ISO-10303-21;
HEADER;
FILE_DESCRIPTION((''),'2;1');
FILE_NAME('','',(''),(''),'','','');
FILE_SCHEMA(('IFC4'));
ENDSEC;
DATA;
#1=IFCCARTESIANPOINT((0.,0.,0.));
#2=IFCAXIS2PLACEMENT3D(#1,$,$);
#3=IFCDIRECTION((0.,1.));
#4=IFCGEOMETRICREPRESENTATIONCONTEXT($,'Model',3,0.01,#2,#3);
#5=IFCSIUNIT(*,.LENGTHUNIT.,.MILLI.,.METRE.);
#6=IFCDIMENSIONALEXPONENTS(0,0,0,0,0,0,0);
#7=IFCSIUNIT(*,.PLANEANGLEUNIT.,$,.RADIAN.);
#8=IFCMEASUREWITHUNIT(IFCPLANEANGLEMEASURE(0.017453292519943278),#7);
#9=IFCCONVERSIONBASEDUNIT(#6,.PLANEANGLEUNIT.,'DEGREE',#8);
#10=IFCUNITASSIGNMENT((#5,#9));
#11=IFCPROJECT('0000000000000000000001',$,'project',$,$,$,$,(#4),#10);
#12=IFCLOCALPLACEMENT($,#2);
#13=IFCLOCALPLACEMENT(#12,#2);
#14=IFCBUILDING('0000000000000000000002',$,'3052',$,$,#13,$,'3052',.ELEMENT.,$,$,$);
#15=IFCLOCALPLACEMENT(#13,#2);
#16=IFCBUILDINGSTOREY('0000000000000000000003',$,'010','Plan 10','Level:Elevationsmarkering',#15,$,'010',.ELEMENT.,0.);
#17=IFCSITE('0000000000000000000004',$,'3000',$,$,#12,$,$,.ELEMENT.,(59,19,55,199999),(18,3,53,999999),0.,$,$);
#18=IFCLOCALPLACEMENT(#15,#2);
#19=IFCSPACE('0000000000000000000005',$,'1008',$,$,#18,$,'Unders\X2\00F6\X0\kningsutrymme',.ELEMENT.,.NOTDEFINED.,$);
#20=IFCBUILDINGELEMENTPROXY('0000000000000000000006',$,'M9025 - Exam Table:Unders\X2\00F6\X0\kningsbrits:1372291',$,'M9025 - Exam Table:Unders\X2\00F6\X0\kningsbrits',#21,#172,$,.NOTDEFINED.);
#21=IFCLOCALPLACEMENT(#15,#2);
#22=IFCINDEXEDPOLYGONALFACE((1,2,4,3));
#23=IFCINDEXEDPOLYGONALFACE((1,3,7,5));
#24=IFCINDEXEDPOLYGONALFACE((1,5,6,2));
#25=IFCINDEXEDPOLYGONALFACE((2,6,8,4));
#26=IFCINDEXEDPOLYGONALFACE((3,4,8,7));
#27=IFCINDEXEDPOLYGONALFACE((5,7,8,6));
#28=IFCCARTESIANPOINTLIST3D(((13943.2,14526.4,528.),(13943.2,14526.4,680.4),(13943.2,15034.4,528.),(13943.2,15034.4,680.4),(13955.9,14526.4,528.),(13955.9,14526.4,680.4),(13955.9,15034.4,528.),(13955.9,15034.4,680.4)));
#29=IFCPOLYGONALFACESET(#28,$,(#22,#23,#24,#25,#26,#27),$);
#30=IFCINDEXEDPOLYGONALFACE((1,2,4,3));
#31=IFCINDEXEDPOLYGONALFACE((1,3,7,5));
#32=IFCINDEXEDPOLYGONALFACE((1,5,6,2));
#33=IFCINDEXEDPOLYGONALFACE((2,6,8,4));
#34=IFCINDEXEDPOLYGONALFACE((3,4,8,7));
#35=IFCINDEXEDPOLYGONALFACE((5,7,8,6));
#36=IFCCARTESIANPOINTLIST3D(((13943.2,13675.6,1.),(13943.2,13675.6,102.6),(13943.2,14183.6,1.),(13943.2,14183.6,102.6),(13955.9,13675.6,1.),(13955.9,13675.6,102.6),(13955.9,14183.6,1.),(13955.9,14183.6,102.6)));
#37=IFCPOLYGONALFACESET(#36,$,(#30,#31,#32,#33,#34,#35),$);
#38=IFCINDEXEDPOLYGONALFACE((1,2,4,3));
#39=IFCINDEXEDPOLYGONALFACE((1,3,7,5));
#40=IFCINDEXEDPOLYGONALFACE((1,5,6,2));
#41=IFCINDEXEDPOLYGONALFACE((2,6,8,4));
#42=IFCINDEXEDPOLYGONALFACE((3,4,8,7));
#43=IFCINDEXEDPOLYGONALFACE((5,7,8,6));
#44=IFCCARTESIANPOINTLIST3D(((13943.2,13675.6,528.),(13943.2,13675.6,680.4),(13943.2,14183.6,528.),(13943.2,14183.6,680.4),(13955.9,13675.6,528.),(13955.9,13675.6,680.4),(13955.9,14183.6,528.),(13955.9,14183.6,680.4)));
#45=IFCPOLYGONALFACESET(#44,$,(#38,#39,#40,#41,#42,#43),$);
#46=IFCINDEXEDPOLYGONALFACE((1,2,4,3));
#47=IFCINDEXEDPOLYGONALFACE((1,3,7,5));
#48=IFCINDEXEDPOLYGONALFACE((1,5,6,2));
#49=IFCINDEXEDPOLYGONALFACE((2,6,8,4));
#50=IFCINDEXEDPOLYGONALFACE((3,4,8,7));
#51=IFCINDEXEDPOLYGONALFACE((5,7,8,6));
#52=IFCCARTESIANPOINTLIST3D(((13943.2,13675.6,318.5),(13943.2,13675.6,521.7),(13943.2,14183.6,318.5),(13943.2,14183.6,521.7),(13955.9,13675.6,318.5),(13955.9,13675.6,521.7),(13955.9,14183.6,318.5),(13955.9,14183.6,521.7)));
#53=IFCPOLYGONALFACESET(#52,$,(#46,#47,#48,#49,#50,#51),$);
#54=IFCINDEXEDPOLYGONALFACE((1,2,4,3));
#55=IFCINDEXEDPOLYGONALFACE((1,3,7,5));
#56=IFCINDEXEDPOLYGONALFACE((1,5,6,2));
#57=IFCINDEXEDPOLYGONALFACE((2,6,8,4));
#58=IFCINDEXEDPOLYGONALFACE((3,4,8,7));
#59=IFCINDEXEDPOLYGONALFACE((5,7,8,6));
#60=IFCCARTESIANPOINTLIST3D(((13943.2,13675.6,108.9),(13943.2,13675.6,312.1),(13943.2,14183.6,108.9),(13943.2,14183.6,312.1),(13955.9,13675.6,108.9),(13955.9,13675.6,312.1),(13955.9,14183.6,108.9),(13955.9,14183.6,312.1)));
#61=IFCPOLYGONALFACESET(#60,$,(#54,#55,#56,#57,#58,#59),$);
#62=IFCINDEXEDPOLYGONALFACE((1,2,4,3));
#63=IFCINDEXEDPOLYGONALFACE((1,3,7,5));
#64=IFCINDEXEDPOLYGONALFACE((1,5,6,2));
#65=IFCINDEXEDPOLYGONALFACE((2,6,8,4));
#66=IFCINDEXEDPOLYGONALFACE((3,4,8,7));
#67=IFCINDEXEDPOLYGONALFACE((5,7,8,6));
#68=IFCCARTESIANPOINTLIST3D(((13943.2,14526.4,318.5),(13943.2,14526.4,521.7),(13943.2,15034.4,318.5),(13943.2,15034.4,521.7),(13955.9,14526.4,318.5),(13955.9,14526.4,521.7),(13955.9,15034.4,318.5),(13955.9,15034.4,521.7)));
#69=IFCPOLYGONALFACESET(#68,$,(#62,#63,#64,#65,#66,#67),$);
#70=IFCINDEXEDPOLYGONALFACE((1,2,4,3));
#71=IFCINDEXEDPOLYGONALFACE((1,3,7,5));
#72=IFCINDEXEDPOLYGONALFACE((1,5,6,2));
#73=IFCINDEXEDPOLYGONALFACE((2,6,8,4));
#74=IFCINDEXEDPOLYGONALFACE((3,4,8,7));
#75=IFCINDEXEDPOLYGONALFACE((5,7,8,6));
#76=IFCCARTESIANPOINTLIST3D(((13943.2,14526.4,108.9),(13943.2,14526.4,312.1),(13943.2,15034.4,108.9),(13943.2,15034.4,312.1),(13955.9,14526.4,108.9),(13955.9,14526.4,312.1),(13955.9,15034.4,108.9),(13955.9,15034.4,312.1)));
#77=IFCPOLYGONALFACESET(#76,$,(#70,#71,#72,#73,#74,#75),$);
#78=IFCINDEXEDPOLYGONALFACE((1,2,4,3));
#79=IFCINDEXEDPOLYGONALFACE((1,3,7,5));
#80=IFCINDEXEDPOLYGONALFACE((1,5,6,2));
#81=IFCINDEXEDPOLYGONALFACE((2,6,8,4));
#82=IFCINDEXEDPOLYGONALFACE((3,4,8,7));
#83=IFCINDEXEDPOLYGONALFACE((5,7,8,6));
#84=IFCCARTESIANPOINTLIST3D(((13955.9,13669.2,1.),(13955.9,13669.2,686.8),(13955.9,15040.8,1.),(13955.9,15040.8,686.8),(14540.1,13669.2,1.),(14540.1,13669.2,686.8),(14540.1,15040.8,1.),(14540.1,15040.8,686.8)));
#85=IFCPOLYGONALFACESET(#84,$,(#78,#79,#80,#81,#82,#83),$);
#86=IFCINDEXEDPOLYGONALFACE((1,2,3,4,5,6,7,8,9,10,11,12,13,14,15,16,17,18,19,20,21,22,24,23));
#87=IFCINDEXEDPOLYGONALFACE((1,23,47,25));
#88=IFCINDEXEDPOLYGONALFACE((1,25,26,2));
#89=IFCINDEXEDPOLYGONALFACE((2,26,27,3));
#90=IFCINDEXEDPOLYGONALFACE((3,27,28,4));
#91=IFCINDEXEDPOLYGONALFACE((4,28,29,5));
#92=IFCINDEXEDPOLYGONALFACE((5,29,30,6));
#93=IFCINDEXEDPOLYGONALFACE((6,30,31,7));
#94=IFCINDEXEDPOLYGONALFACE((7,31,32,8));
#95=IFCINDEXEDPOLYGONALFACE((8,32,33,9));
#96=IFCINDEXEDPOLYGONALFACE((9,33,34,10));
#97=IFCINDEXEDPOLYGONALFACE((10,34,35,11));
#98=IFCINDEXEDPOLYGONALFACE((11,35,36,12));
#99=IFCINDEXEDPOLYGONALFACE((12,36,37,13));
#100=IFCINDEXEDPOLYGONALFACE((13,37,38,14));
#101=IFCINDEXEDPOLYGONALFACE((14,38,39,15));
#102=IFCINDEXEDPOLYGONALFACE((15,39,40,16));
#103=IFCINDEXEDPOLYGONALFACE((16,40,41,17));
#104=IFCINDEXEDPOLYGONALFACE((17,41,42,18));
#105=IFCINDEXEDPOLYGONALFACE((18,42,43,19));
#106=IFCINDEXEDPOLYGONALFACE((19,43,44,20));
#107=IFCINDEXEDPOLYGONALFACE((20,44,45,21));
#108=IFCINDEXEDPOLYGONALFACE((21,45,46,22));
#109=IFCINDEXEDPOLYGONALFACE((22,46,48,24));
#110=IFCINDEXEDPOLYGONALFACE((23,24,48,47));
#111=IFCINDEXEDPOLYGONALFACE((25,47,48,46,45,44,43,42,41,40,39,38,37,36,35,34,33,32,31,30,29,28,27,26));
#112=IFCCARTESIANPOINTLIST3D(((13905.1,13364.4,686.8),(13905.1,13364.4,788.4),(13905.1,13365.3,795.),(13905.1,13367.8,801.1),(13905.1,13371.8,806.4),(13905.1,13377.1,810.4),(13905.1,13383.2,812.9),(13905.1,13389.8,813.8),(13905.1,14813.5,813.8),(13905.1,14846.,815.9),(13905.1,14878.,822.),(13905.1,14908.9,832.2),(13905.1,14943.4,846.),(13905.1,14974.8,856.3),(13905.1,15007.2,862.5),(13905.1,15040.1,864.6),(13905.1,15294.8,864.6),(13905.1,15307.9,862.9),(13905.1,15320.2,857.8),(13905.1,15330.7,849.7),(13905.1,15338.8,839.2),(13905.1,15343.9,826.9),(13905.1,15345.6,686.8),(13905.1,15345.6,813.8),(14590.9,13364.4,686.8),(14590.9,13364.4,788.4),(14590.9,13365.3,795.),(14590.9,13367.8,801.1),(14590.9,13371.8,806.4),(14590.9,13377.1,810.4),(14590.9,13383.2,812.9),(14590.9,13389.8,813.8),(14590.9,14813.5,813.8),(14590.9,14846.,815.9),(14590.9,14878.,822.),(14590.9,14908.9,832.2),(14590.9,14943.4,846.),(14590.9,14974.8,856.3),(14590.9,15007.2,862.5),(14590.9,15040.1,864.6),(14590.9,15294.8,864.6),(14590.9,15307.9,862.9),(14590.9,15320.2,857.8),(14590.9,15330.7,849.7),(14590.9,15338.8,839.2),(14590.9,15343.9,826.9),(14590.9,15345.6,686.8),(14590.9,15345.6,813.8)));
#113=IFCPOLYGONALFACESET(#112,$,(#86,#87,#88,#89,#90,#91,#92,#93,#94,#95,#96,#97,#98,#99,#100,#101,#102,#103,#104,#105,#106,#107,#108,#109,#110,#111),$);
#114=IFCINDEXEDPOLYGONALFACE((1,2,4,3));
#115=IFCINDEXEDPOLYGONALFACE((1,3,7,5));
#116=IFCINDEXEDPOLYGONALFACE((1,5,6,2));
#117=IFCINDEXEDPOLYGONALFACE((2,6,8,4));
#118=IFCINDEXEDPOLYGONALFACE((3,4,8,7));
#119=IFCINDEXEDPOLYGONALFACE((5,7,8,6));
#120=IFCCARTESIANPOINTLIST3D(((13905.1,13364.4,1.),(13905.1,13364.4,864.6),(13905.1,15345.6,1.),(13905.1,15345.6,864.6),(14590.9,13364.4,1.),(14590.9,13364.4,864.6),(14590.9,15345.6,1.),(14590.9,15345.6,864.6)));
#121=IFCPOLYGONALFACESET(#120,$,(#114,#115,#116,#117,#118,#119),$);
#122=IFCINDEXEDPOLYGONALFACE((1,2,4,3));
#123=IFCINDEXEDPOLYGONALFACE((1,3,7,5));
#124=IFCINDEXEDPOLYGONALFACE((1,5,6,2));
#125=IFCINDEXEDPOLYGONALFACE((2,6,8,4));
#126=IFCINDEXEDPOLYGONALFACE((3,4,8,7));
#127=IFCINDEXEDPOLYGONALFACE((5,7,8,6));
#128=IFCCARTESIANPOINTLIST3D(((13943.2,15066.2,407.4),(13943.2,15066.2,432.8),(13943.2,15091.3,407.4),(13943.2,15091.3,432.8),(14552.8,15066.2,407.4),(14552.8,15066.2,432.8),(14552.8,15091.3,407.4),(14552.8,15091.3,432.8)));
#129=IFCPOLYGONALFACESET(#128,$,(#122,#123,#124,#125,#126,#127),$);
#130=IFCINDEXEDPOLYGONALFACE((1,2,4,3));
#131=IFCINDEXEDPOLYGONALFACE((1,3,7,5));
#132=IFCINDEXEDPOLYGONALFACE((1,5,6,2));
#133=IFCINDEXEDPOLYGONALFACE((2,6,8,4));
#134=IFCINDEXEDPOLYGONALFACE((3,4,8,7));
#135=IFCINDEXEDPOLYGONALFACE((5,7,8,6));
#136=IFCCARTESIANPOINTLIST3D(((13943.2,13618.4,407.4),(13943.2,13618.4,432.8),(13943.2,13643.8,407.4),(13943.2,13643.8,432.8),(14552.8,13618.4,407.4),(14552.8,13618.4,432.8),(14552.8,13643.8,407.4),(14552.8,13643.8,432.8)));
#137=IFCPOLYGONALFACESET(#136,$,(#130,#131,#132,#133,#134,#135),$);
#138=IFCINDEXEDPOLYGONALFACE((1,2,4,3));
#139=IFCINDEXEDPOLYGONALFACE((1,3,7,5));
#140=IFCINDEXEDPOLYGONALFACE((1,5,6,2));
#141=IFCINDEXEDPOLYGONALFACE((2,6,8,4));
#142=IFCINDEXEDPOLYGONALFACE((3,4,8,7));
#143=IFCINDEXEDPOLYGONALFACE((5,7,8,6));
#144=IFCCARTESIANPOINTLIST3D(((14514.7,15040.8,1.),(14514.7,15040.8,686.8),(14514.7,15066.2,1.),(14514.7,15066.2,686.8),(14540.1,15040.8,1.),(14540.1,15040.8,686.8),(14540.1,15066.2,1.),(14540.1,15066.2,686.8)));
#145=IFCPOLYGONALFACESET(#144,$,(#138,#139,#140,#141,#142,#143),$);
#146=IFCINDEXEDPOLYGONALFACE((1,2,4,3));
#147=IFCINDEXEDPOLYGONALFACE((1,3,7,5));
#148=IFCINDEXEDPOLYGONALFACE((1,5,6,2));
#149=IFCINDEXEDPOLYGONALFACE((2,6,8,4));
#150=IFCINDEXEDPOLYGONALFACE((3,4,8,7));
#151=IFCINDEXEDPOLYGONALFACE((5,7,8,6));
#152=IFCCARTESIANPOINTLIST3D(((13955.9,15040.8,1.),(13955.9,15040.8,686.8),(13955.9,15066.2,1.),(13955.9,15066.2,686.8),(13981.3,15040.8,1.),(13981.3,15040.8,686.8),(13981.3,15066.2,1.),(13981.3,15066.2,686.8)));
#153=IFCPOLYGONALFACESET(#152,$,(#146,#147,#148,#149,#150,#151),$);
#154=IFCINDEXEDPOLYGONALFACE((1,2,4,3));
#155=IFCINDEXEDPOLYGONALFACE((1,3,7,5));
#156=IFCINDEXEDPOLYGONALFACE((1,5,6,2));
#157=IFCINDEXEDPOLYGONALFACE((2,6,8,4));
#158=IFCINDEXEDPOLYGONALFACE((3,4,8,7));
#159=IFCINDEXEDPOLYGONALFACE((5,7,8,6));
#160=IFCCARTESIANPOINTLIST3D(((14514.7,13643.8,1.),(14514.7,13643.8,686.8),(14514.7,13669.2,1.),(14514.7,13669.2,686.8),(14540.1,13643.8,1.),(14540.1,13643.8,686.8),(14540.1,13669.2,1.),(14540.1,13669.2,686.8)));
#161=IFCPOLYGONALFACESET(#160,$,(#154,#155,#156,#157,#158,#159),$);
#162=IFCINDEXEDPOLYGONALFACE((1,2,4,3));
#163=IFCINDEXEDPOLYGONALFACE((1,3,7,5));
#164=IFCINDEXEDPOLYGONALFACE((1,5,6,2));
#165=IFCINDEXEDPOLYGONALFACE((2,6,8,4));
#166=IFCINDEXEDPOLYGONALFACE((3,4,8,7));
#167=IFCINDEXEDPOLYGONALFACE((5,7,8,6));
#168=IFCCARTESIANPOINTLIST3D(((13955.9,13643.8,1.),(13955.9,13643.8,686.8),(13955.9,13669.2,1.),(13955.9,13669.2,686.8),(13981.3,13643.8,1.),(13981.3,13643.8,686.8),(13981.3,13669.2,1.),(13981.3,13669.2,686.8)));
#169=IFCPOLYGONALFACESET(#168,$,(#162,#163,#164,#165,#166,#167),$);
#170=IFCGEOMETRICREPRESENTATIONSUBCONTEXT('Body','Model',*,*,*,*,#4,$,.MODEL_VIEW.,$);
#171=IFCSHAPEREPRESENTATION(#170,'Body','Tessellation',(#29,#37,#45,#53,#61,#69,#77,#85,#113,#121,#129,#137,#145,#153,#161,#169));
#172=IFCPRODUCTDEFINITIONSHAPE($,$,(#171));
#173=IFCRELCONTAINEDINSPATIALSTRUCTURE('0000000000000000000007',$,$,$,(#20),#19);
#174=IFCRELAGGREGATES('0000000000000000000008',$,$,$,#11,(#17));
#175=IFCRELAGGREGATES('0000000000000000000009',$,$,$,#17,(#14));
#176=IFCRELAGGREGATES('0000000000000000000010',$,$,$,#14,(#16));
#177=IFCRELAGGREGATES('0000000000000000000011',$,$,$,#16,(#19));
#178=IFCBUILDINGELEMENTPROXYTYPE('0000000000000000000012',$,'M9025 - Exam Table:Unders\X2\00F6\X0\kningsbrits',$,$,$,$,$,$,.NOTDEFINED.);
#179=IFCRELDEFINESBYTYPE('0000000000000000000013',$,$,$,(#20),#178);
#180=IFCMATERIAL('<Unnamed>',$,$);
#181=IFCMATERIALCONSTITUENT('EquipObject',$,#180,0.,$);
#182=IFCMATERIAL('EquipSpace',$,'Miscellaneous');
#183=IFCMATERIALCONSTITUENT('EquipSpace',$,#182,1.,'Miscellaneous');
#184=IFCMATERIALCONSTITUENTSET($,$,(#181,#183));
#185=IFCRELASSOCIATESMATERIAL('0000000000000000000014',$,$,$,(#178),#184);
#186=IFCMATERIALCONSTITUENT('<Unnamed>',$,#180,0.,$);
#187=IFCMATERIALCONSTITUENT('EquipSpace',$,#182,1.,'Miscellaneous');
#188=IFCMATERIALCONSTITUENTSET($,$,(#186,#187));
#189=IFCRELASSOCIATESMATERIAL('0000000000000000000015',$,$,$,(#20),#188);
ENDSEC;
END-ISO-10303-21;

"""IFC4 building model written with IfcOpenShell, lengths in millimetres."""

from ifc_helpers import new_model, entity, si_unit, converted_unit, direction, frame, origin, place, context, subcontext, project, spatial, line, arc, indexed_curve, outline, extrude, source, transform, mapped, material, constituent, constituent_set, type_object, type_shapes, element, save


model = new_model("IFC4")

# Units and contexts
model_context = context("Model", 3, precision=0.01, world=origin(), true_north=direction((0.0, 1.0)))
body_context = subcontext(model_context, "Body", "Model", "MODEL_VIEW")
ifc_project = project(units=[si_unit("LENGTHUNIT", "METRE", prefix="MILLI"), converted_unit("PLANEANGLEUNIT", "DEGREE", entity("IfcPlaneAngleMeasure", 0.017453292519943278), si_unit("PLANEANGLEUNIT", "RADIAN"), dimensions=[0, 0, 0, 0, 0, 0, 0])], contexts=[model_context])

# Site, building, storey
site_placement = place(None, origin())
site = spatial("IfcSite", under=ifc_project, at=site_placement, Name="3000", CompositionType="ELEMENT", RefLatitude=(59, 19, 55, 199999), RefLongitude=(18, 3, 53, 999999), RefElevation=0.0)
building_placement = place(site_placement, origin())
building = spatial("IfcBuilding", under=site, at=building_placement, Name="3052", LongName="3052", CompositionType="ELEMENT")
storey_placement = place(building_placement, origin())
storey = spatial("IfcBuildingStorey", under=building, at=storey_placement, Name="010", Description="Plan 10", ObjectType="Level:Elevationsmarkering", LongName="010", CompositionType="ELEMENT", Elevation=0.0)

# Shared definitions
space_1_placement = place(storey_placement, origin())
space_1 = spatial("IfcSpace", under=storey, at=space_1_placement, Name="1008", LongName="Undersökningsutrymme", CompositionType="ELEMENT", PredefinedType="NOTDEFINED")

# Building element proxy
ifc_material_1 = material(Name="<Unnamed>")
ifc_constituent_1 = constituent(ifc_material_1, Name="<Unnamed>", fraction=0.0)
ifc_material_2 = material(Name="EquipSpace", Category="Miscellaneous")
ifc_constituent_2 = constituent(ifc_material_2, Name="EquipSpace", Category="Miscellaneous", fraction=1.0)
ifc_constituent_set_1 = constituent_set(constituents=[ifc_constituent_1, ifc_constituent_2])
ifc_constituent_3 = constituent(ifc_material_1, Name="EquipObject", fraction=0.0)
ifc_constituent_4 = constituent(ifc_material_2, Name="EquipSpace", Category="Miscellaneous", fraction=1.0)
ifc_constituent_set_2 = constituent_set(constituents=[ifc_constituent_3, ifc_constituent_4])
building_element_proxy_type = type_object("IfcBuildingElementProxyType", Name="M9025 - Exam Table:Undersökningsbrits", PredefinedType="NOTDEFINED", material=ifc_constituent_set_2)
shared_shape_1 = source(origin(), body_context, "Body", "SweptSolid", [
    extrude(outline(indexed_curve([(-6.3, -254.0), (6.3, -254.0), (6.3, 254.0), (-6.3, 254.0), (-6.3, -254.0)], self_intersect=False)), frame((-298.4, 425.4, 527.0), z_axis=(0.0, 0.0, 1.0), x_axis=(-1.0, 0.0, 0.0)), (0.0, 0.0, 1.0), 152.4),
    extrude(outline(indexed_curve([(-6.3, -254.0), (6.3, -254.0), (6.3, 254.0), (-6.3, 254.0), (-6.3, -254.0)], self_intersect=False)), frame((-298.4, -425.4, 0.0), z_axis=(0.0, 0.0, 1.0), x_axis=(-1.0, 0.0, 0.0)), (0.0, 0.0, 1.0), 101.6),
    extrude(outline(indexed_curve([(-6.3, -254.0), (6.3, -254.0), (6.3, 254.0), (-6.3, 254.0), (-6.3, -254.0)], self_intersect=False)), frame((-298.4, -425.4, 527.0), z_axis=(0.0, 0.0, 1.0), x_axis=(-1.0, 0.0, 0.0)), (0.0, 0.0, 1.0), 152.4),
    extrude(outline(indexed_curve([(-6.3, -254.0), (6.3, -254.0), (6.3, 254.0), (-6.3, 254.0), (-6.3, -254.0)], self_intersect=False)), frame((-298.4, -425.4, 317.5), z_axis=(0.0, 0.0, 1.0), x_axis=(-1.0, 0.0, 0.0)), (0.0, 0.0, 1.0), 203.2),
    extrude(outline(indexed_curve([(-6.3, -254.0), (6.3, -254.0), (6.3, 254.0), (-6.3, 254.0), (-6.3, -254.0)], self_intersect=False)), frame((-298.4, -425.4, 107.9), z_axis=(0.0, 0.0, 1.0), x_axis=(-1.0, 0.0, 0.0)), (0.0, 0.0, 1.0), 203.2),
    extrude(outline(indexed_curve([(-6.3, -254.0), (6.3, -254.0), (6.3, 254.0), (-6.3, 254.0), (-6.3, -254.0)], self_intersect=False)), frame((-298.4, 425.4, 317.5), z_axis=(0.0, 0.0, 1.0), x_axis=(-1.0, 0.0, 0.0)), (0.0, 0.0, 1.0), 203.2),
    extrude(outline(indexed_curve([(-6.3, -254.0), (6.3, -254.0), (6.3, 254.0), (-6.3, 254.0), (-6.3, -254.0)], self_intersect=False)), frame((-298.4, 425.4, 107.9), z_axis=(0.0, 0.0, 1.0), x_axis=(-1.0, 0.0, 0.0)), (0.0, 0.0, 1.0), 203.2),
    extrude(outline(indexed_curve([(-292.1, -685.8), (292.1, -685.8), (292.1, 685.8), (-292.1, 685.8), (-292.1, -685.8)], self_intersect=False)), frame((0.0, 0.0, 0.0), z_axis=(0.0, 0.0, 1.0), x_axis=(-1.0, 0.0, 0.0)), (0.0, 0.0, 1.0), 685.8),
    extrude(outline(indexed_curve([(-114.3, -764.5), (12.7, -764.5), (48.6, -749.7), (63.5, -713.7), (63.5, -459.1), (58.8, -409.8), (44.9, -362.4), (31.1, -327.9), (17.4, -281.0), (12.7, -232.5), (12.7, 1191.3), (5.3, 1209.2), (-12.7, 1216.7), (-114.3, 1216.7)], segments=[line(1, 2), arc(2, 3, 4), line(4, 5), arc(5, 6, 7), line(7, 8), arc(8, 9, 10), line(10, 11), arc(11, 12, 13), line(13, 14, 1)], self_intersect=False)), frame((-342.9, 226.1, 800.1), z_axis=(1.0, 0.0, 0.0), x_axis=(0.0, 0.0, 1.0)), (0.0, 0.0, 1.0), 685.8),
    extrude(outline(indexed_curve([(-342.9, -990.6), (342.9, -990.6), (342.9, 990.6), (-342.9, 990.6), (-342.9, -990.6)], self_intersect=False)), frame((0.0, 0.0, 0.0), z_axis=(0.0, 0.0, 1.0), x_axis=(-1.0, 0.0, 0.0)), (0.0, 0.0, 1.0), 863.6),
    extrude(outline(indexed_curve([(-304.8, -12.5), (304.8, -12.5), (304.8, 12.5), (-304.8, 12.5), (-304.8, -12.5)], self_intersect=False)), frame((0.0, 723.7, 406.4), z_axis=(0.0, 0.0, 1.0), x_axis=(-1.0, 0.0, 0.0)), (0.0, 0.0, 1.0), 25.4),
    extrude(outline(indexed_curve([(-304.8, -12.7), (304.8, -12.7), (304.8, 12.7), (-304.8, 12.7), (-304.8, -12.7)], self_intersect=False)), frame((0.0, -723.9, 406.4), z_axis=(0.0, 0.0, 1.0), x_axis=(-1.0, 0.0, 0.0)), (0.0, 0.0, 1.0), 25.4),
    extrude(outline(indexed_curve([(-12.7, -12.7), (12.7, -12.7), (12.7, 12.7), (-12.7, 12.7), (-12.7, -12.7)], self_intersect=False)), frame((279.4, 698.5, 0.0), z_axis=(0.0, 0.0, 1.0), x_axis=(0.0, 1.0, 0.0)), (0.0, 0.0, 1.0), 685.8),
    extrude(outline(indexed_curve([(-12.7, -12.7), (12.7, -12.7), (12.7, 12.7), (-12.7, 12.7), (-12.7, -12.7)], self_intersect=False)), frame((-279.4, 698.5, 0.0)), (0.0, 0.0, 1.0), 685.8),
    extrude(outline(indexed_curve([(-12.7, -12.7), (12.7, -12.7), (12.7, 12.7), (-12.7, 12.7), (-12.7, -12.7)], self_intersect=False)), frame((279.4, -698.5, 0.0), z_axis=(0.0, 0.0, 1.0), x_axis=(-1.0, 0.0, 0.0)), (0.0, 0.0, 1.0), 685.8),
    extrude(outline(indexed_curve([(-12.7, -12.7), (12.7, -12.7), (12.7, 12.7), (-12.7, 12.7), (-12.7, -12.7)], self_intersect=False)), frame((-279.4, -698.5, 0.0), z_axis=(0.0, 0.0, 1.0), x_axis=(0.0, -1.0, 0.0)), (0.0, 0.0, 1.0), 685.8),
])
type_shapes(building_element_proxy_type, [shared_shape_1])
proxy_1_placement = place(space_1_placement, frame((14248.0, 14355.0, 1.0)))
element("IfcBuildingElementProxy", 1, at=proxy_1_placement, inside=space_1, type_object=building_element_proxy_type, material=ifc_constituent_set_1, Name="M9025 - Exam Table:Undersökningsbrits:1372291", ObjectType="M9025 - Exam Table:Undersökningsbrits", PredefinedType="NOTDEFINED", context=body_context, shape_type="MappedRepresentation", body=[
    mapped(shared_shape_1, transform((0.0, 0.0, 0.0), scale=1.0)),
])

save(model, "model.ifc")
